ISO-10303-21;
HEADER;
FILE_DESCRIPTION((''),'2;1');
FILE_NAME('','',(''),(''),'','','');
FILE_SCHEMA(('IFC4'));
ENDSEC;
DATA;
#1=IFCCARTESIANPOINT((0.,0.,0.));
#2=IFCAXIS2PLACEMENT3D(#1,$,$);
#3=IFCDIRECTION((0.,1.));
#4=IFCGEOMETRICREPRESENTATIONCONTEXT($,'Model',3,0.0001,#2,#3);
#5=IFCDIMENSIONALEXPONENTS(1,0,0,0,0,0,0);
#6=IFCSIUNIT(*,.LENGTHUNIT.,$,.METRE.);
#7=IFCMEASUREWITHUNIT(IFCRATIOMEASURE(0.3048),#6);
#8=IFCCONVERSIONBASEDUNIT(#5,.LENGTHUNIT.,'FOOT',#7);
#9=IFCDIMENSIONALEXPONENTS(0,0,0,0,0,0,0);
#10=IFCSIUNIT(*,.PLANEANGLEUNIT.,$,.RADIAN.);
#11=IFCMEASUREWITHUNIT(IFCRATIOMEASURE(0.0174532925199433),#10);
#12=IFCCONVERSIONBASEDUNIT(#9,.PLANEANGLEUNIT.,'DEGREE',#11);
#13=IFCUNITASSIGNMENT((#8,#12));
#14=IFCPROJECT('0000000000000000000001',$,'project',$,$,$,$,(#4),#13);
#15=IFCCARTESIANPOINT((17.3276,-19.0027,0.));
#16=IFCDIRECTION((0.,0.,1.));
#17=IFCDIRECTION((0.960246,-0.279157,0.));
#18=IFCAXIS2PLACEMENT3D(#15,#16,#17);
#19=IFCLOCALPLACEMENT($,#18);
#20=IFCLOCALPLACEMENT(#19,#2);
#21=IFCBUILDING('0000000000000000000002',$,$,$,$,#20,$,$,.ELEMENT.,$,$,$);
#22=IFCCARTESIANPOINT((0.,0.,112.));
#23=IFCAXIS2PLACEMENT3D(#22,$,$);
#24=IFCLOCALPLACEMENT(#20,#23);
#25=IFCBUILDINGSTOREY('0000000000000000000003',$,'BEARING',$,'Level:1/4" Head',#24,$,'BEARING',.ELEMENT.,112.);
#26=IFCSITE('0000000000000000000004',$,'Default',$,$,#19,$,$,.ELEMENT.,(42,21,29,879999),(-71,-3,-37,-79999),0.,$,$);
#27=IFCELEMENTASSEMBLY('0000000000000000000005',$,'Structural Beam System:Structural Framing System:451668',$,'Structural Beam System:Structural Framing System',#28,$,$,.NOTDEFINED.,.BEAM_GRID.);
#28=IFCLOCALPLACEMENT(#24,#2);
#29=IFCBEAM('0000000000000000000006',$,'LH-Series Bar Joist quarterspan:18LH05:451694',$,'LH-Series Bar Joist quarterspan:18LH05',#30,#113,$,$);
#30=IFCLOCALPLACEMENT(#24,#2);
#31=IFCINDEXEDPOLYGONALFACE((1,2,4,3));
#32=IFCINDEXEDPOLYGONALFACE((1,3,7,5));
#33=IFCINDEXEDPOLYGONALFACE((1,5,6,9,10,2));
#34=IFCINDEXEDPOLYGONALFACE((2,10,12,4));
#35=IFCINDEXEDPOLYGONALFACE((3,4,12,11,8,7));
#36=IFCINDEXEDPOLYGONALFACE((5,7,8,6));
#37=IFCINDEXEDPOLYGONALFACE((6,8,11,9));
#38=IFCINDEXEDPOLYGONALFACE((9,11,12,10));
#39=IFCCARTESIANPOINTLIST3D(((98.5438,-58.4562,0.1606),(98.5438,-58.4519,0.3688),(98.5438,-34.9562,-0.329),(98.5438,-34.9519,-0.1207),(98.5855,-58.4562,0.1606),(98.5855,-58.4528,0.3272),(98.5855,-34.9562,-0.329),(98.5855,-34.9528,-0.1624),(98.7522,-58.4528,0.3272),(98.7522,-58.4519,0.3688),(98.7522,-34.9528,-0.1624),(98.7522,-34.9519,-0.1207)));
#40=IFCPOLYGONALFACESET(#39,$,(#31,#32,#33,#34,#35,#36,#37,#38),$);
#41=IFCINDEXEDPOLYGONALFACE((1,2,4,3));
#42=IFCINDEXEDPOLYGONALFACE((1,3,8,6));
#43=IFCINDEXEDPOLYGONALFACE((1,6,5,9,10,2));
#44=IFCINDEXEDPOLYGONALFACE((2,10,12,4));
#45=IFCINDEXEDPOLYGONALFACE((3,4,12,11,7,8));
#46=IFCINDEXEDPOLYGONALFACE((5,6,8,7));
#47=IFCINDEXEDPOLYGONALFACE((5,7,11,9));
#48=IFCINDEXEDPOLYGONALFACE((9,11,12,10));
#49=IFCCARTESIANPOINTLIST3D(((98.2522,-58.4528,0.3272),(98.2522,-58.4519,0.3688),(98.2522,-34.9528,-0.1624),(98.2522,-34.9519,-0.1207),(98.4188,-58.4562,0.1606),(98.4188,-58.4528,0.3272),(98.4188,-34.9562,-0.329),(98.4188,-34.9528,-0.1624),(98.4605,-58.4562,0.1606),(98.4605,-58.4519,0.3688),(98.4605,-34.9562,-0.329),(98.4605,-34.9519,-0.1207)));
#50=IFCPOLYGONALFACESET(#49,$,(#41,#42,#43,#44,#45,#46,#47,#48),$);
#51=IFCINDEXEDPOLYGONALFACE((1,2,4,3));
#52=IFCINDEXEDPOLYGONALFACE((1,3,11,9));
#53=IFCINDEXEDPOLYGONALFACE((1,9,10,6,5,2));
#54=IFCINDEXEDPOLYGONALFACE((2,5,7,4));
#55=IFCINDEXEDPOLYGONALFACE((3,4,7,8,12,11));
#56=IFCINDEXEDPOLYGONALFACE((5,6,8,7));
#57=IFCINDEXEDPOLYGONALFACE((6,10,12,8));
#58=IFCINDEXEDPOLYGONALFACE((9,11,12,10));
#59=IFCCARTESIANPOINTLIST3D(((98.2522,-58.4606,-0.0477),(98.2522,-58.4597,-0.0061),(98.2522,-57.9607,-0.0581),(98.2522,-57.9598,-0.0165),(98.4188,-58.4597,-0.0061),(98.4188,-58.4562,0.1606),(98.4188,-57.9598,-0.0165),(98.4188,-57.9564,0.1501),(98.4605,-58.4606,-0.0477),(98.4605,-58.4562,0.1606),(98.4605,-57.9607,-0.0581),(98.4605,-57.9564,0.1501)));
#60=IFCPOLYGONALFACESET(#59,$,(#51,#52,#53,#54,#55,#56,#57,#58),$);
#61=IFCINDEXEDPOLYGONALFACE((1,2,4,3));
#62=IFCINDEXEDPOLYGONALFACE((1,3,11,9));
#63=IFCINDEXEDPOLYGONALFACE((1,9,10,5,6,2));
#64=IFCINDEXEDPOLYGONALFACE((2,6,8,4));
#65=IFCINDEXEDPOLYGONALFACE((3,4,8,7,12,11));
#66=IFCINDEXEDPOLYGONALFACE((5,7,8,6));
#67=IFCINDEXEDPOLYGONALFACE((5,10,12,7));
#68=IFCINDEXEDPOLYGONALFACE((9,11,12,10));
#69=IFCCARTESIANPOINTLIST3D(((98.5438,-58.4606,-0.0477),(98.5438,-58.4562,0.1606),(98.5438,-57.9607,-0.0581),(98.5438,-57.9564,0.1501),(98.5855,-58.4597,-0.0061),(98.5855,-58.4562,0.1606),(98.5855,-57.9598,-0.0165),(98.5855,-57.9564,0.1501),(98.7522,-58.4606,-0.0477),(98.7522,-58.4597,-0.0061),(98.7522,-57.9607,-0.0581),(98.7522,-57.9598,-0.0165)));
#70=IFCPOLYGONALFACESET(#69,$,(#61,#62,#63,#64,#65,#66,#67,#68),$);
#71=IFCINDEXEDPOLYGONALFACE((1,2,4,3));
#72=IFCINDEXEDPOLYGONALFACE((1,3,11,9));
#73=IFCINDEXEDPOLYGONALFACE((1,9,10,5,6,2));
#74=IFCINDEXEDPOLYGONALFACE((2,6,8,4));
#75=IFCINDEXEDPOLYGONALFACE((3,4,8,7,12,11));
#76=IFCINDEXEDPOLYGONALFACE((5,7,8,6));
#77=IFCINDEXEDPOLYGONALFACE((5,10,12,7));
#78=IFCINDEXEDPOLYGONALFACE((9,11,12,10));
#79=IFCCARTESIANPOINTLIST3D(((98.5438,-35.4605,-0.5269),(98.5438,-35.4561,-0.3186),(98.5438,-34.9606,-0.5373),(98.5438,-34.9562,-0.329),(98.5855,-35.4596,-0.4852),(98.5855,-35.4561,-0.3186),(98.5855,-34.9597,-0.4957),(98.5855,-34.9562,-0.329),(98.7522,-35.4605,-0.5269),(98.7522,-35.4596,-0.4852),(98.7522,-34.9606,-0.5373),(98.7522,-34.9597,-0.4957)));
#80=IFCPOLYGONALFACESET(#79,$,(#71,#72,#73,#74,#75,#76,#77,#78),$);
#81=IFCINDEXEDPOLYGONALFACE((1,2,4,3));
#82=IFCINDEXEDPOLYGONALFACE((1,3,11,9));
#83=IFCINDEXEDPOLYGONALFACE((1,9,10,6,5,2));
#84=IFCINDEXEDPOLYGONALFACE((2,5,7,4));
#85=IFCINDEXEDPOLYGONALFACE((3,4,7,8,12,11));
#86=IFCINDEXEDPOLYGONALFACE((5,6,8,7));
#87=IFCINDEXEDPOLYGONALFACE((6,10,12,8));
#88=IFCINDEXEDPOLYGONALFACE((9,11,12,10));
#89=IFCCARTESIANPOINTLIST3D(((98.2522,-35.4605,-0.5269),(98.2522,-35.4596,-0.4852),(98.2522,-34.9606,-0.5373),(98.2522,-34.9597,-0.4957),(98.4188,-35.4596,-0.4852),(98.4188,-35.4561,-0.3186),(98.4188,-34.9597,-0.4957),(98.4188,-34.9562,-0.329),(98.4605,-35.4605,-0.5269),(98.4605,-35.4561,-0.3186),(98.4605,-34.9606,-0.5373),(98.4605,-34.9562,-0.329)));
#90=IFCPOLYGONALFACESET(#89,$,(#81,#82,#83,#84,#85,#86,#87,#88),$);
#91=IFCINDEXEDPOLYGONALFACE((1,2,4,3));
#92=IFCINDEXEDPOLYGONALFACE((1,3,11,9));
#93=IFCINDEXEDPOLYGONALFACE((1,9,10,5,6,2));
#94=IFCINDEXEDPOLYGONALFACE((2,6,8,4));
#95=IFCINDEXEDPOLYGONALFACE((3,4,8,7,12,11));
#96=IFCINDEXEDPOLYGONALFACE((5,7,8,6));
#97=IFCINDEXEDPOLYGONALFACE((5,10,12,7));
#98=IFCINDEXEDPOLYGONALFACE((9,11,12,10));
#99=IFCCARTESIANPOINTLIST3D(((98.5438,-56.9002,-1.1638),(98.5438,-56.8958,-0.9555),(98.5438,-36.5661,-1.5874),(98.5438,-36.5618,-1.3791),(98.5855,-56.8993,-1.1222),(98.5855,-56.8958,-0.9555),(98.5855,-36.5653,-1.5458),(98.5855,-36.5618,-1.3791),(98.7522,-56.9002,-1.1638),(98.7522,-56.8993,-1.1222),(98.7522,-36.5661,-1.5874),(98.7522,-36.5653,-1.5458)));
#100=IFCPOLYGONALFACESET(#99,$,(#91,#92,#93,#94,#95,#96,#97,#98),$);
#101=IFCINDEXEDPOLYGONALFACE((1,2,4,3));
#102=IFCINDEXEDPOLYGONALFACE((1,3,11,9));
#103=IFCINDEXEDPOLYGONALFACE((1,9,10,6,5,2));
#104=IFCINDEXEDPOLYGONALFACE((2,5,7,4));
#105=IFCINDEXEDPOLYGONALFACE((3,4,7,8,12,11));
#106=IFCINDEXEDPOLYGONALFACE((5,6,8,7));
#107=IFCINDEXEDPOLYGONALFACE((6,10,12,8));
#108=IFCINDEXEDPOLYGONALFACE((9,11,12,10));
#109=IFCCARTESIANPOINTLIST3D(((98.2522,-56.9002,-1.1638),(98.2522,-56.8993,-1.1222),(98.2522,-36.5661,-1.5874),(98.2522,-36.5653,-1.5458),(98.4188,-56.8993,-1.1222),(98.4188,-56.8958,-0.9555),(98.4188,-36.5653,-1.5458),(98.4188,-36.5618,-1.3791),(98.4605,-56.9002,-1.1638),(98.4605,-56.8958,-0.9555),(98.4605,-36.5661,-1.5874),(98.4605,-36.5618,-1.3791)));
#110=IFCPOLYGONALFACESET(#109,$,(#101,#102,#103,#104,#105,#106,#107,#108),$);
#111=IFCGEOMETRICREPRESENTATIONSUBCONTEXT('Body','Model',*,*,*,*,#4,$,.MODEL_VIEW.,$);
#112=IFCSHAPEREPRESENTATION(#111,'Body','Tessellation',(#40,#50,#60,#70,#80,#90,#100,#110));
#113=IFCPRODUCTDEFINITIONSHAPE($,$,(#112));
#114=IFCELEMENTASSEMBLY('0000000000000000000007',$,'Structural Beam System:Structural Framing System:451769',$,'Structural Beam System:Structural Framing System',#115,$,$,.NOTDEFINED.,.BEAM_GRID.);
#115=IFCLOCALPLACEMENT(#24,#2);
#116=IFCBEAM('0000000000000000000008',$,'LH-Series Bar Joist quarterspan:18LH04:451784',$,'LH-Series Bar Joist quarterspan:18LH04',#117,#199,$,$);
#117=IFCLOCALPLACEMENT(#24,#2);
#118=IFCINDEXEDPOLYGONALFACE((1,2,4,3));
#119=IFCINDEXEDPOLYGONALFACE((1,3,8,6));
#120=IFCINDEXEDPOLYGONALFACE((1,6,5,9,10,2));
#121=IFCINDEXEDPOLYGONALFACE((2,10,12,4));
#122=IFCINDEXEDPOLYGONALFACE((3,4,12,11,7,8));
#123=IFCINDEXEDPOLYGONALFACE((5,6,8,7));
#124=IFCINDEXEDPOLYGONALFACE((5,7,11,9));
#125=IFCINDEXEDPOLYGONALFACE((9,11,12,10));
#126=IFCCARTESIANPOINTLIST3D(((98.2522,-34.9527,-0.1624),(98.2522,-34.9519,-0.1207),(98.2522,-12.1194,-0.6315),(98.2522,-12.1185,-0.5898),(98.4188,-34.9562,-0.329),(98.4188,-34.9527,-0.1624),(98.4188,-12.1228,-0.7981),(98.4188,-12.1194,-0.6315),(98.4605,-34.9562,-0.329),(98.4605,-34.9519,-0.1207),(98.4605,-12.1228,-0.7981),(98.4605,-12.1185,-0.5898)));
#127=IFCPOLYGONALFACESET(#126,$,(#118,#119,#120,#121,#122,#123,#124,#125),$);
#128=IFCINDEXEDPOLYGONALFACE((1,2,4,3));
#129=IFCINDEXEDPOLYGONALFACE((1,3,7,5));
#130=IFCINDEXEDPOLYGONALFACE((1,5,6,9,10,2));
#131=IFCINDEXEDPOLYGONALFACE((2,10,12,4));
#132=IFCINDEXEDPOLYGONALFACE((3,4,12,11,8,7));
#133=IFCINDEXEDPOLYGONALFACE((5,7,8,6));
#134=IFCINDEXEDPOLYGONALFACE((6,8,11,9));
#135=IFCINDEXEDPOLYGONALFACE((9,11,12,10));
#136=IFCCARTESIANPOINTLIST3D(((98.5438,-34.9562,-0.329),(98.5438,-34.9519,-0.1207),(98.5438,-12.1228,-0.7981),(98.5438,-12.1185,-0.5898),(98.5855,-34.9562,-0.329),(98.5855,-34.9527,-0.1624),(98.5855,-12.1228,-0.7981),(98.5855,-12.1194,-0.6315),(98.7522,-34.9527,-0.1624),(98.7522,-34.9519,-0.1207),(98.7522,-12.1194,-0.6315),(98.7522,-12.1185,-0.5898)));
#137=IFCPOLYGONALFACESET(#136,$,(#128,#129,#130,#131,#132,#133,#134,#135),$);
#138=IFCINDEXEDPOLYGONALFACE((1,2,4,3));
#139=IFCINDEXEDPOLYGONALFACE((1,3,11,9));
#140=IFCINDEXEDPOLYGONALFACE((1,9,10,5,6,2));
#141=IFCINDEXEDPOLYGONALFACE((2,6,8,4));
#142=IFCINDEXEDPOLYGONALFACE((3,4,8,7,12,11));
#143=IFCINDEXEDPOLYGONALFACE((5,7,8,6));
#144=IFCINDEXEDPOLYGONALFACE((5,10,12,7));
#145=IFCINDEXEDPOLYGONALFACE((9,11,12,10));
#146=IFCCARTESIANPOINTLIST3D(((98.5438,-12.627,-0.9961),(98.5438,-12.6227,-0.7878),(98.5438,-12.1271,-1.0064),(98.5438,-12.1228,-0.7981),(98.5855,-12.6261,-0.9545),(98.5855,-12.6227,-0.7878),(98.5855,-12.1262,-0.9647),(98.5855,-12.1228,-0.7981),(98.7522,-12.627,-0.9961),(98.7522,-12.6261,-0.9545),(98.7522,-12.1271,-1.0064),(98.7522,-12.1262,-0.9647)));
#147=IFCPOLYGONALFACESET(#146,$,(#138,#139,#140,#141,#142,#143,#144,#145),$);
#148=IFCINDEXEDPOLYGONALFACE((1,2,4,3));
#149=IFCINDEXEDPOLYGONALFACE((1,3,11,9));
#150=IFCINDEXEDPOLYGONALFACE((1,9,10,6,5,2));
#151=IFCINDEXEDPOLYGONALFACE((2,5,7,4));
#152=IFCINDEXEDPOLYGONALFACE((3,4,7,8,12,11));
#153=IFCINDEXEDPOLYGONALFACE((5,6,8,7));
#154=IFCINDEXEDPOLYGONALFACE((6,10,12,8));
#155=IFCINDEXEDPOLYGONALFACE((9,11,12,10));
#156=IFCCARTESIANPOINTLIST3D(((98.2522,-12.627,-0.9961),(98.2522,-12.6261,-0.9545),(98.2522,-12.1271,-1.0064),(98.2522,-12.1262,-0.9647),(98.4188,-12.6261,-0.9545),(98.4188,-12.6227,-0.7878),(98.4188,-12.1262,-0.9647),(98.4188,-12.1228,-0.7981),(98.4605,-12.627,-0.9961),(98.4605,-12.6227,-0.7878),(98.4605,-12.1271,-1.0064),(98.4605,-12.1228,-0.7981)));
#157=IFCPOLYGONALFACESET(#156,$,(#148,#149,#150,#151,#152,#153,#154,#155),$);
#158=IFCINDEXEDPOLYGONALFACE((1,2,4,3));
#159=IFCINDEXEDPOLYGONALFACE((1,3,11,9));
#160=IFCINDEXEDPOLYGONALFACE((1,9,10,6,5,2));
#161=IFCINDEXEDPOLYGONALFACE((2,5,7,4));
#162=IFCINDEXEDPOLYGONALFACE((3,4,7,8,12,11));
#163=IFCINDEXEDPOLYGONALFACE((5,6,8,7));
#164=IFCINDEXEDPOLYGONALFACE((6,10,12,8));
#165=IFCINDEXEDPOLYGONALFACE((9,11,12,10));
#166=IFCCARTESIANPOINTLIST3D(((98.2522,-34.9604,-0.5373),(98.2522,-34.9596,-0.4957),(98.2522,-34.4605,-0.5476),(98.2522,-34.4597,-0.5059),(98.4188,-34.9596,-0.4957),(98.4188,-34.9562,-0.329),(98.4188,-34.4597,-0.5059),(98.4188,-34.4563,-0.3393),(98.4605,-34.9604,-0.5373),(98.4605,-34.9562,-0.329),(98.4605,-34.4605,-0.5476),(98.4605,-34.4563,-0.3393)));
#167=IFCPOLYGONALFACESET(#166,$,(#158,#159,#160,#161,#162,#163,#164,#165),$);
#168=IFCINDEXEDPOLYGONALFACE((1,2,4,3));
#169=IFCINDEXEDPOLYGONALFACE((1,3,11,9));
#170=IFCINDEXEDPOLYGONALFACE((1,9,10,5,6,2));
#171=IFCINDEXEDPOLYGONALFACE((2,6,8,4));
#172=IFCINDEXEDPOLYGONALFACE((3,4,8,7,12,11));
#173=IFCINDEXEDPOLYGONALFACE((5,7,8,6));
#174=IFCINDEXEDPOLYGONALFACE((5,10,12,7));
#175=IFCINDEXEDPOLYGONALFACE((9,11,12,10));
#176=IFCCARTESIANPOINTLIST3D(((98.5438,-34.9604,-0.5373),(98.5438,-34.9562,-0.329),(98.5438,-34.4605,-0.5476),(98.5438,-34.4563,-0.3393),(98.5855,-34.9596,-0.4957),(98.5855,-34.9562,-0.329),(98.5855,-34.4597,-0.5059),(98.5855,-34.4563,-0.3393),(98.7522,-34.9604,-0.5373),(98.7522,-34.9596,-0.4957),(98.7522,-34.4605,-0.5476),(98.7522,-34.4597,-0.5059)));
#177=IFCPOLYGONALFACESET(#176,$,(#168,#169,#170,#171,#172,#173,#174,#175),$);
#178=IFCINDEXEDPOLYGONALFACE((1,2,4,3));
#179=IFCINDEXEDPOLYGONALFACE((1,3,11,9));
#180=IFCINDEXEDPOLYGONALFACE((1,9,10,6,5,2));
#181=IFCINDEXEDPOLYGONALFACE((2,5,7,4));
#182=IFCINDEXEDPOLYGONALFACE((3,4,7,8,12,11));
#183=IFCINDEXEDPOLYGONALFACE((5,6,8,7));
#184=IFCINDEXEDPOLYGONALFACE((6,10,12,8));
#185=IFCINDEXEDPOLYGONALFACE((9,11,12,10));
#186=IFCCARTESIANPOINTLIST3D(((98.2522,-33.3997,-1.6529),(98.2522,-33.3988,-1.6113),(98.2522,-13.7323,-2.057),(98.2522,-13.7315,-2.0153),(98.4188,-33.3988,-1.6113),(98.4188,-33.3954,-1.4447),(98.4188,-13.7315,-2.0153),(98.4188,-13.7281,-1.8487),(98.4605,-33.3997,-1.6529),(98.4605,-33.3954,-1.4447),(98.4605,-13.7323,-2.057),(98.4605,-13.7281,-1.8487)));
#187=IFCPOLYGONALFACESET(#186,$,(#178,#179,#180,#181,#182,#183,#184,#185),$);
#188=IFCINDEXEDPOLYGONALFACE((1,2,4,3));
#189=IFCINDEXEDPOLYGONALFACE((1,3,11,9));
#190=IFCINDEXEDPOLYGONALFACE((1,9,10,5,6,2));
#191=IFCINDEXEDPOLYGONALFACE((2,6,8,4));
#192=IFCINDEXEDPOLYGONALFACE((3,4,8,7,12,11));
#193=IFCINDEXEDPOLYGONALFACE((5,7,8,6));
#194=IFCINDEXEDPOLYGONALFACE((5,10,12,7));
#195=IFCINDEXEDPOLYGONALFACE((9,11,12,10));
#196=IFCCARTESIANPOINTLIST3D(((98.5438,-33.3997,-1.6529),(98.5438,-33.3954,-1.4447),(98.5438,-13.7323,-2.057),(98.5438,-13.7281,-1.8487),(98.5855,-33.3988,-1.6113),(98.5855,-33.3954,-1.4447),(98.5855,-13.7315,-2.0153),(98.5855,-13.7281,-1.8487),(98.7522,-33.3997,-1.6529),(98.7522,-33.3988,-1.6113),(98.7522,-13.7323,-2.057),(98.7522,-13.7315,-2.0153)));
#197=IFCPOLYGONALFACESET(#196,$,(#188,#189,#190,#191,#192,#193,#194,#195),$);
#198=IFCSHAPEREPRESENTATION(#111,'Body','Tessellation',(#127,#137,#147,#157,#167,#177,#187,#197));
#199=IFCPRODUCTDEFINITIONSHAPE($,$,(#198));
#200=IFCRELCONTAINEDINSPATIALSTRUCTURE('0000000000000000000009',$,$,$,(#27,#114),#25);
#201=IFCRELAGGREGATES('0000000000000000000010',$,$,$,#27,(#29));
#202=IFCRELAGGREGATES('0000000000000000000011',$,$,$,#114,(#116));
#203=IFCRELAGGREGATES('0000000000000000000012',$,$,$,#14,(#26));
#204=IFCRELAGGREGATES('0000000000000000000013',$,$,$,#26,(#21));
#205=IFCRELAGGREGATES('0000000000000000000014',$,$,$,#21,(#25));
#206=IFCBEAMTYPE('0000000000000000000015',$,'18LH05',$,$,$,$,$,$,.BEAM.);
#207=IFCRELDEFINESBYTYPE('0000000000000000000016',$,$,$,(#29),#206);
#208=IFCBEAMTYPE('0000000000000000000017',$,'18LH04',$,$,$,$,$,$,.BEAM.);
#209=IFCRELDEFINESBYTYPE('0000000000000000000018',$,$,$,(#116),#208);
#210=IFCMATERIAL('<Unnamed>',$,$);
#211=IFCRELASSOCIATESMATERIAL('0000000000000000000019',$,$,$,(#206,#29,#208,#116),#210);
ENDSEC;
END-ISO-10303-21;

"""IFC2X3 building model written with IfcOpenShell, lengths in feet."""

from ifc_helpers import new_model, entity, si_unit, converted_unit, direction, frame, origin, place, context, subcontext, project, spatial, polyline, outline, extrude, source, transform, mapped, material, type_object, type_shapes, element, aggregate, save


model = new_model("IFC2X3")

# Units and contexts
model_context = context("Model", 3, precision=0.0001, world=origin(), true_north=direction((0.0, 1.0)))
body_context = subcontext(model_context, "Body", "Model", "MODEL_VIEW")
ifc_project = project(units=[converted_unit("LENGTHUNIT", "FOOT", entity("IfcRatioMeasure", 0.3048), si_unit("LENGTHUNIT", "METRE"), dimensions=[1, 0, 0, 0, 0, 0, 0]), converted_unit("PLANEANGLEUNIT", "DEGREE", entity("IfcRatioMeasure", 0.0174532925199433), si_unit("PLANEANGLEUNIT", "RADIAN"), dimensions=[0, 0, 0, 0, 0, 0, 0])], contexts=[model_context])

# Site, building, storey
site_placement = place(None, frame((17.3276, -19.0027, 0.0), z_axis=(0.0, 0.0, 1.0), x_axis=(0.960246, -0.279157, 0.0)))
site = spatial("IfcSite", under=ifc_project, at=site_placement, Name="Default", CompositionType="ELEMENT", RefLatitude=(42, 21, 29, 879999), RefLongitude=(-71, -3, -37, -79999), RefElevation=0.0)
building_placement = place(site_placement, origin())
building = spatial("IfcBuilding", under=site, at=building_placement, CompositionType="ELEMENT")
storey_placement = place(building_placement, frame((0.0, 0.0, 112.0)))
storey = spatial("IfcBuildingStorey", under=building, at=storey_placement, Name="BEARING", ObjectType="Level:1/4\" Head", LongName="BEARING", CompositionType="ELEMENT", Elevation=112.0)

# Element assemblies, beams
assembly_1_placement = place(storey_placement, origin())
assembly_1 = element("IfcElementAssembly", 1, at=assembly_1_placement, inside=storey, Name="Structural Beam System:Structural Framing System:451668", ObjectType="Structural Beam System:Structural Framing System", AssemblyPlace="NOTDEFINED", PredefinedType="BEAM_GRID")
ifc_material_1 = material(Name="<Unnamed>")
beam_type_1 = type_object("IfcBeamType", Name="18LH05", PredefinedType="BEAM", material=ifc_material_1)
shared_shape_1 = source(origin(), body_context, "Body", "SweptSolid", [
    extrude(outline(polyline([(-0.0833, -0.125), (-0.0417, -0.125), (-0.0417, 0.0417), (0.125, 0.0417), (0.125, 0.0833), (-0.0833, 0.0833), (-0.0833, -0.125)])), frame((-11.7525, -0.125, 0.6667), z_axis=(1.0, 0.0, 0.0), x_axis=(0.0, 0.0, -1.0)), (0.0, 0.0, 1.0), 23.5051),
    extrude(outline(polyline([(-0.0833, -0.0833), (0.125, -0.0833), (0.125, -0.0417), (-0.0417, -0.0417), (-0.0417, 0.125), (-0.0833, 0.125), (-0.0833, -0.0833)])), frame((-11.7525, 0.125, 0.6667), z_axis=(1.0, 0.0, 0.0), x_axis=(0.0, 0.0, -1.0)), (0.0, 0.0, 1.0), 23.5051),
    extrude(outline(polyline([(-0.125, -0.0833), (0.0833, -0.0833), (0.0833, 0.125), (0.0417, 0.125), (0.0417, -0.0417), (-0.125, -0.0417), (-0.125, -0.0833)])), frame((-11.7525, 0.125, 0.4167), z_axis=(1.0, 0.0, 0.0), x_axis=(0.0, 0.0, -1.0)), (0.0, 0.0, 1.0), 0.5),
    extrude(outline(polyline([(0.0417, -0.125), (0.0833, -0.125), (0.0833, 0.0833), (-0.125, 0.0833), (-0.125, 0.0417), (0.0417, 0.0417), (0.0417, -0.125)])), frame((-11.7525, -0.125, 0.4167), z_axis=(1.0, 0.0, 0.0), x_axis=(0.0, 0.0, -1.0)), (0.0, 0.0, 1.0), 0.5),
    extrude(outline(polyline([(0.0417, -0.125), (0.0833, -0.125), (0.0833, 0.0833), (-0.125, 0.0833), (-0.125, 0.0417), (0.0417, 0.0417), (0.0417, -0.125)])), frame((11.2525, -0.125, 0.4167), z_axis=(1.0, 0.0, 0.0), x_axis=(0.0, 0.0, -1.0)), (0.0, 0.0, 1.0), 0.5),
    extrude(outline(polyline([(-0.125, -0.0833), (0.0833, -0.0833), (0.0833, 0.125), (0.0417, 0.125), (0.0417, -0.0417), (-0.125, -0.0417), (-0.125, -0.0833)])), frame((11.2525, 0.125, 0.4167), z_axis=(1.0, 0.0, 0.0), x_axis=(0.0, 0.0, -1.0)), (0.0, 0.0, 1.0), 0.5),
    extrude(outline(polyline([(0.0417, -0.125), (0.0833, -0.125), (0.0833, 0.0833), (-0.125, 0.0833), (-0.125, 0.0417), (0.0417, 0.0417), (0.0417, -0.125)])), frame((-10.1692, -0.125, -0.6667), z_axis=(1.0, 0.0, 0.0), x_axis=(0.0, 0.0, -1.0)), (0.0, 0.0, 1.0), 20.3384),
    extrude(outline(polyline([(-0.125, -0.0833), (0.0833, -0.0833), (0.0833, 0.125), (0.0417, 0.125), (0.0417, -0.0417), (-0.125, -0.0417), (-0.125, -0.0833)])), frame((-10.1692, 0.125, -0.6667), z_axis=(1.0, 0.0, 0.0), x_axis=(0.0, 0.0, -1.0)), (0.0, 0.0, 1.0), 20.3384),
])
type_shapes(beam_type_1, [shared_shape_1])
beam_1_placement = place(assembly_1_placement, frame((98.5022, -46.7175, -0.6258), z_axis=(0.0, 0.020829, 0.999783), x_axis=(0.0, 0.999783, -0.020829)))
beam_1 = element("IfcBeam", 2, at=beam_1_placement, type_object=beam_type_1, material=ifc_material_1, Name="LH-Series Bar Joist quarterspan:18LH05:451694", ObjectType="LH-Series Bar Joist quarterspan:18LH05", context=body_context, shape_type="MappedRepresentation", body=[
    mapped(shared_shape_1, transform((0.0, 0.0, 0.0), scale=1.0)),
])
aggregate(assembly_1, [beam_1])
assembly_2_placement = place(storey_placement, origin())
assembly_2 = element("IfcElementAssembly", 3, at=assembly_2_placement, inside=storey, Name="Structural Beam System:Structural Framing System:451769", ObjectType="Structural Beam System:Structural Framing System", AssemblyPlace="NOTDEFINED", PredefinedType="BEAM_GRID")
beam_type_2 = type_object("IfcBeamType", Name="18LH04", PredefinedType="BEAM", material=ifc_material_1)
shared_shape_2 = source(origin(), body_context, "Body", "SweptSolid", [
    extrude(outline(polyline([(-0.0833, -0.125), (-0.0417, -0.125), (-0.0417, 0.0417), (0.125, 0.0417), (0.125, 0.0833), (-0.0833, 0.0833), (-0.0833, -0.125)])), frame((-11.4191, -0.125, 0.6667), z_axis=(1.0, 0.0, 0.0), x_axis=(0.0, 0.0, -1.0)), (0.0, 0.0, 1.0), 22.8382),
    extrude(outline(polyline([(-0.0833, -0.0833), (0.125, -0.0833), (0.125, -0.0417), (-0.0417, -0.0417), (-0.0417, 0.125), (-0.0833, 0.125), (-0.0833, -0.0833)])), frame((-11.4191, 0.125, 0.6667), z_axis=(1.0, 0.0, 0.0), x_axis=(0.0, 0.0, -1.0)), (0.0, 0.0, 1.0), 22.8382),
    extrude(outline(polyline([(-0.125, -0.0833), (0.0833, -0.0833), (0.0833, 0.125), (0.0417, 0.125), (0.0417, -0.0417), (-0.125, -0.0417), (-0.125, -0.0833)])), frame((-11.4191, 0.125, 0.4167), z_axis=(1.0, 0.0, 0.0), x_axis=(0.0, 0.0, -1.0)), (0.0, 0.0, 1.0), 0.5),
    extrude(outline(polyline([(0.0417, -0.125), (0.0833, -0.125), (0.0833, 0.0833), (-0.125, 0.0833), (-0.125, 0.0417), (0.0417, 0.0417), (0.0417, -0.125)])), frame((-11.4191, -0.125, 0.4167), z_axis=(1.0, 0.0, 0.0), x_axis=(0.0, 0.0, -1.0)), (0.0, 0.0, 1.0), 0.5),
    extrude(outline(polyline([(0.0417, -0.125), (0.0833, -0.125), (0.0833, 0.0833), (-0.125, 0.0833), (-0.125, 0.0417), (0.0417, 0.0417), (0.0417, -0.125)])), frame((10.9191, -0.125, 0.4167), z_axis=(1.0, 0.0, 0.0), x_axis=(0.0, 0.0, -1.0)), (0.0, 0.0, 1.0), 0.5),
    extrude(outline(polyline([(-0.125, -0.0833), (0.0833, -0.0833), (0.0833, 0.125), (0.0417, 0.125), (0.0417, -0.0417), (-0.125, -0.0417), (-0.125, -0.0833)])), frame((10.9191, 0.125, 0.4167), z_axis=(1.0, 0.0, 0.0), x_axis=(0.0, 0.0, -1.0)), (0.0, 0.0, 1.0), 0.5),
    extrude(outline(polyline([(0.0417, -0.125), (0.0833, -0.125), (0.0833, 0.0833), (-0.125, 0.0833), (-0.125, 0.0417), (0.0417, 0.0417), (0.0417, -0.125)])), frame((-9.8357, -0.125, -0.6667), z_axis=(1.0, 0.0, 0.0), x_axis=(0.0, 0.0, -1.0)), (0.0, 0.0, 1.0), 19.6715),
    extrude(outline(polyline([(-0.125, -0.0833), (0.0833, -0.0833), (0.0833, 0.125), (0.0417, 0.125), (0.0417, -0.0417), (-0.125, -0.0417), (-0.125, -0.0833)])), frame((-9.8357, 0.125, -0.6667), z_axis=(1.0, 0.0, 0.0), x_axis=(0.0, 0.0, -1.0)), (0.0, 0.0, 1.0), 19.6715),
])
type_shapes(beam_type_2, [shared_shape_2])
beam_2_placement = place(assembly_2_placement, frame((98.5022, -23.5506, -1.1051), z_axis=(0.0, 0.020539, 0.999789), x_axis=(0.0, -0.999789, 0.020539)))
beam_2 = element("IfcBeam", 4, at=beam_2_placement, type_object=beam_type_2, material=ifc_material_1, Name="LH-Series Bar Joist quarterspan:18LH04:451784", ObjectType="LH-Series Bar Joist quarterspan:18LH04", context=body_context, shape_type="MappedRepresentation", body=[
    mapped(shared_shape_2, transform((0.0, 0.0, 0.0), scale=1.0)),
])
aggregate(assembly_2, [beam_2])

save(model, "model.ifc")
